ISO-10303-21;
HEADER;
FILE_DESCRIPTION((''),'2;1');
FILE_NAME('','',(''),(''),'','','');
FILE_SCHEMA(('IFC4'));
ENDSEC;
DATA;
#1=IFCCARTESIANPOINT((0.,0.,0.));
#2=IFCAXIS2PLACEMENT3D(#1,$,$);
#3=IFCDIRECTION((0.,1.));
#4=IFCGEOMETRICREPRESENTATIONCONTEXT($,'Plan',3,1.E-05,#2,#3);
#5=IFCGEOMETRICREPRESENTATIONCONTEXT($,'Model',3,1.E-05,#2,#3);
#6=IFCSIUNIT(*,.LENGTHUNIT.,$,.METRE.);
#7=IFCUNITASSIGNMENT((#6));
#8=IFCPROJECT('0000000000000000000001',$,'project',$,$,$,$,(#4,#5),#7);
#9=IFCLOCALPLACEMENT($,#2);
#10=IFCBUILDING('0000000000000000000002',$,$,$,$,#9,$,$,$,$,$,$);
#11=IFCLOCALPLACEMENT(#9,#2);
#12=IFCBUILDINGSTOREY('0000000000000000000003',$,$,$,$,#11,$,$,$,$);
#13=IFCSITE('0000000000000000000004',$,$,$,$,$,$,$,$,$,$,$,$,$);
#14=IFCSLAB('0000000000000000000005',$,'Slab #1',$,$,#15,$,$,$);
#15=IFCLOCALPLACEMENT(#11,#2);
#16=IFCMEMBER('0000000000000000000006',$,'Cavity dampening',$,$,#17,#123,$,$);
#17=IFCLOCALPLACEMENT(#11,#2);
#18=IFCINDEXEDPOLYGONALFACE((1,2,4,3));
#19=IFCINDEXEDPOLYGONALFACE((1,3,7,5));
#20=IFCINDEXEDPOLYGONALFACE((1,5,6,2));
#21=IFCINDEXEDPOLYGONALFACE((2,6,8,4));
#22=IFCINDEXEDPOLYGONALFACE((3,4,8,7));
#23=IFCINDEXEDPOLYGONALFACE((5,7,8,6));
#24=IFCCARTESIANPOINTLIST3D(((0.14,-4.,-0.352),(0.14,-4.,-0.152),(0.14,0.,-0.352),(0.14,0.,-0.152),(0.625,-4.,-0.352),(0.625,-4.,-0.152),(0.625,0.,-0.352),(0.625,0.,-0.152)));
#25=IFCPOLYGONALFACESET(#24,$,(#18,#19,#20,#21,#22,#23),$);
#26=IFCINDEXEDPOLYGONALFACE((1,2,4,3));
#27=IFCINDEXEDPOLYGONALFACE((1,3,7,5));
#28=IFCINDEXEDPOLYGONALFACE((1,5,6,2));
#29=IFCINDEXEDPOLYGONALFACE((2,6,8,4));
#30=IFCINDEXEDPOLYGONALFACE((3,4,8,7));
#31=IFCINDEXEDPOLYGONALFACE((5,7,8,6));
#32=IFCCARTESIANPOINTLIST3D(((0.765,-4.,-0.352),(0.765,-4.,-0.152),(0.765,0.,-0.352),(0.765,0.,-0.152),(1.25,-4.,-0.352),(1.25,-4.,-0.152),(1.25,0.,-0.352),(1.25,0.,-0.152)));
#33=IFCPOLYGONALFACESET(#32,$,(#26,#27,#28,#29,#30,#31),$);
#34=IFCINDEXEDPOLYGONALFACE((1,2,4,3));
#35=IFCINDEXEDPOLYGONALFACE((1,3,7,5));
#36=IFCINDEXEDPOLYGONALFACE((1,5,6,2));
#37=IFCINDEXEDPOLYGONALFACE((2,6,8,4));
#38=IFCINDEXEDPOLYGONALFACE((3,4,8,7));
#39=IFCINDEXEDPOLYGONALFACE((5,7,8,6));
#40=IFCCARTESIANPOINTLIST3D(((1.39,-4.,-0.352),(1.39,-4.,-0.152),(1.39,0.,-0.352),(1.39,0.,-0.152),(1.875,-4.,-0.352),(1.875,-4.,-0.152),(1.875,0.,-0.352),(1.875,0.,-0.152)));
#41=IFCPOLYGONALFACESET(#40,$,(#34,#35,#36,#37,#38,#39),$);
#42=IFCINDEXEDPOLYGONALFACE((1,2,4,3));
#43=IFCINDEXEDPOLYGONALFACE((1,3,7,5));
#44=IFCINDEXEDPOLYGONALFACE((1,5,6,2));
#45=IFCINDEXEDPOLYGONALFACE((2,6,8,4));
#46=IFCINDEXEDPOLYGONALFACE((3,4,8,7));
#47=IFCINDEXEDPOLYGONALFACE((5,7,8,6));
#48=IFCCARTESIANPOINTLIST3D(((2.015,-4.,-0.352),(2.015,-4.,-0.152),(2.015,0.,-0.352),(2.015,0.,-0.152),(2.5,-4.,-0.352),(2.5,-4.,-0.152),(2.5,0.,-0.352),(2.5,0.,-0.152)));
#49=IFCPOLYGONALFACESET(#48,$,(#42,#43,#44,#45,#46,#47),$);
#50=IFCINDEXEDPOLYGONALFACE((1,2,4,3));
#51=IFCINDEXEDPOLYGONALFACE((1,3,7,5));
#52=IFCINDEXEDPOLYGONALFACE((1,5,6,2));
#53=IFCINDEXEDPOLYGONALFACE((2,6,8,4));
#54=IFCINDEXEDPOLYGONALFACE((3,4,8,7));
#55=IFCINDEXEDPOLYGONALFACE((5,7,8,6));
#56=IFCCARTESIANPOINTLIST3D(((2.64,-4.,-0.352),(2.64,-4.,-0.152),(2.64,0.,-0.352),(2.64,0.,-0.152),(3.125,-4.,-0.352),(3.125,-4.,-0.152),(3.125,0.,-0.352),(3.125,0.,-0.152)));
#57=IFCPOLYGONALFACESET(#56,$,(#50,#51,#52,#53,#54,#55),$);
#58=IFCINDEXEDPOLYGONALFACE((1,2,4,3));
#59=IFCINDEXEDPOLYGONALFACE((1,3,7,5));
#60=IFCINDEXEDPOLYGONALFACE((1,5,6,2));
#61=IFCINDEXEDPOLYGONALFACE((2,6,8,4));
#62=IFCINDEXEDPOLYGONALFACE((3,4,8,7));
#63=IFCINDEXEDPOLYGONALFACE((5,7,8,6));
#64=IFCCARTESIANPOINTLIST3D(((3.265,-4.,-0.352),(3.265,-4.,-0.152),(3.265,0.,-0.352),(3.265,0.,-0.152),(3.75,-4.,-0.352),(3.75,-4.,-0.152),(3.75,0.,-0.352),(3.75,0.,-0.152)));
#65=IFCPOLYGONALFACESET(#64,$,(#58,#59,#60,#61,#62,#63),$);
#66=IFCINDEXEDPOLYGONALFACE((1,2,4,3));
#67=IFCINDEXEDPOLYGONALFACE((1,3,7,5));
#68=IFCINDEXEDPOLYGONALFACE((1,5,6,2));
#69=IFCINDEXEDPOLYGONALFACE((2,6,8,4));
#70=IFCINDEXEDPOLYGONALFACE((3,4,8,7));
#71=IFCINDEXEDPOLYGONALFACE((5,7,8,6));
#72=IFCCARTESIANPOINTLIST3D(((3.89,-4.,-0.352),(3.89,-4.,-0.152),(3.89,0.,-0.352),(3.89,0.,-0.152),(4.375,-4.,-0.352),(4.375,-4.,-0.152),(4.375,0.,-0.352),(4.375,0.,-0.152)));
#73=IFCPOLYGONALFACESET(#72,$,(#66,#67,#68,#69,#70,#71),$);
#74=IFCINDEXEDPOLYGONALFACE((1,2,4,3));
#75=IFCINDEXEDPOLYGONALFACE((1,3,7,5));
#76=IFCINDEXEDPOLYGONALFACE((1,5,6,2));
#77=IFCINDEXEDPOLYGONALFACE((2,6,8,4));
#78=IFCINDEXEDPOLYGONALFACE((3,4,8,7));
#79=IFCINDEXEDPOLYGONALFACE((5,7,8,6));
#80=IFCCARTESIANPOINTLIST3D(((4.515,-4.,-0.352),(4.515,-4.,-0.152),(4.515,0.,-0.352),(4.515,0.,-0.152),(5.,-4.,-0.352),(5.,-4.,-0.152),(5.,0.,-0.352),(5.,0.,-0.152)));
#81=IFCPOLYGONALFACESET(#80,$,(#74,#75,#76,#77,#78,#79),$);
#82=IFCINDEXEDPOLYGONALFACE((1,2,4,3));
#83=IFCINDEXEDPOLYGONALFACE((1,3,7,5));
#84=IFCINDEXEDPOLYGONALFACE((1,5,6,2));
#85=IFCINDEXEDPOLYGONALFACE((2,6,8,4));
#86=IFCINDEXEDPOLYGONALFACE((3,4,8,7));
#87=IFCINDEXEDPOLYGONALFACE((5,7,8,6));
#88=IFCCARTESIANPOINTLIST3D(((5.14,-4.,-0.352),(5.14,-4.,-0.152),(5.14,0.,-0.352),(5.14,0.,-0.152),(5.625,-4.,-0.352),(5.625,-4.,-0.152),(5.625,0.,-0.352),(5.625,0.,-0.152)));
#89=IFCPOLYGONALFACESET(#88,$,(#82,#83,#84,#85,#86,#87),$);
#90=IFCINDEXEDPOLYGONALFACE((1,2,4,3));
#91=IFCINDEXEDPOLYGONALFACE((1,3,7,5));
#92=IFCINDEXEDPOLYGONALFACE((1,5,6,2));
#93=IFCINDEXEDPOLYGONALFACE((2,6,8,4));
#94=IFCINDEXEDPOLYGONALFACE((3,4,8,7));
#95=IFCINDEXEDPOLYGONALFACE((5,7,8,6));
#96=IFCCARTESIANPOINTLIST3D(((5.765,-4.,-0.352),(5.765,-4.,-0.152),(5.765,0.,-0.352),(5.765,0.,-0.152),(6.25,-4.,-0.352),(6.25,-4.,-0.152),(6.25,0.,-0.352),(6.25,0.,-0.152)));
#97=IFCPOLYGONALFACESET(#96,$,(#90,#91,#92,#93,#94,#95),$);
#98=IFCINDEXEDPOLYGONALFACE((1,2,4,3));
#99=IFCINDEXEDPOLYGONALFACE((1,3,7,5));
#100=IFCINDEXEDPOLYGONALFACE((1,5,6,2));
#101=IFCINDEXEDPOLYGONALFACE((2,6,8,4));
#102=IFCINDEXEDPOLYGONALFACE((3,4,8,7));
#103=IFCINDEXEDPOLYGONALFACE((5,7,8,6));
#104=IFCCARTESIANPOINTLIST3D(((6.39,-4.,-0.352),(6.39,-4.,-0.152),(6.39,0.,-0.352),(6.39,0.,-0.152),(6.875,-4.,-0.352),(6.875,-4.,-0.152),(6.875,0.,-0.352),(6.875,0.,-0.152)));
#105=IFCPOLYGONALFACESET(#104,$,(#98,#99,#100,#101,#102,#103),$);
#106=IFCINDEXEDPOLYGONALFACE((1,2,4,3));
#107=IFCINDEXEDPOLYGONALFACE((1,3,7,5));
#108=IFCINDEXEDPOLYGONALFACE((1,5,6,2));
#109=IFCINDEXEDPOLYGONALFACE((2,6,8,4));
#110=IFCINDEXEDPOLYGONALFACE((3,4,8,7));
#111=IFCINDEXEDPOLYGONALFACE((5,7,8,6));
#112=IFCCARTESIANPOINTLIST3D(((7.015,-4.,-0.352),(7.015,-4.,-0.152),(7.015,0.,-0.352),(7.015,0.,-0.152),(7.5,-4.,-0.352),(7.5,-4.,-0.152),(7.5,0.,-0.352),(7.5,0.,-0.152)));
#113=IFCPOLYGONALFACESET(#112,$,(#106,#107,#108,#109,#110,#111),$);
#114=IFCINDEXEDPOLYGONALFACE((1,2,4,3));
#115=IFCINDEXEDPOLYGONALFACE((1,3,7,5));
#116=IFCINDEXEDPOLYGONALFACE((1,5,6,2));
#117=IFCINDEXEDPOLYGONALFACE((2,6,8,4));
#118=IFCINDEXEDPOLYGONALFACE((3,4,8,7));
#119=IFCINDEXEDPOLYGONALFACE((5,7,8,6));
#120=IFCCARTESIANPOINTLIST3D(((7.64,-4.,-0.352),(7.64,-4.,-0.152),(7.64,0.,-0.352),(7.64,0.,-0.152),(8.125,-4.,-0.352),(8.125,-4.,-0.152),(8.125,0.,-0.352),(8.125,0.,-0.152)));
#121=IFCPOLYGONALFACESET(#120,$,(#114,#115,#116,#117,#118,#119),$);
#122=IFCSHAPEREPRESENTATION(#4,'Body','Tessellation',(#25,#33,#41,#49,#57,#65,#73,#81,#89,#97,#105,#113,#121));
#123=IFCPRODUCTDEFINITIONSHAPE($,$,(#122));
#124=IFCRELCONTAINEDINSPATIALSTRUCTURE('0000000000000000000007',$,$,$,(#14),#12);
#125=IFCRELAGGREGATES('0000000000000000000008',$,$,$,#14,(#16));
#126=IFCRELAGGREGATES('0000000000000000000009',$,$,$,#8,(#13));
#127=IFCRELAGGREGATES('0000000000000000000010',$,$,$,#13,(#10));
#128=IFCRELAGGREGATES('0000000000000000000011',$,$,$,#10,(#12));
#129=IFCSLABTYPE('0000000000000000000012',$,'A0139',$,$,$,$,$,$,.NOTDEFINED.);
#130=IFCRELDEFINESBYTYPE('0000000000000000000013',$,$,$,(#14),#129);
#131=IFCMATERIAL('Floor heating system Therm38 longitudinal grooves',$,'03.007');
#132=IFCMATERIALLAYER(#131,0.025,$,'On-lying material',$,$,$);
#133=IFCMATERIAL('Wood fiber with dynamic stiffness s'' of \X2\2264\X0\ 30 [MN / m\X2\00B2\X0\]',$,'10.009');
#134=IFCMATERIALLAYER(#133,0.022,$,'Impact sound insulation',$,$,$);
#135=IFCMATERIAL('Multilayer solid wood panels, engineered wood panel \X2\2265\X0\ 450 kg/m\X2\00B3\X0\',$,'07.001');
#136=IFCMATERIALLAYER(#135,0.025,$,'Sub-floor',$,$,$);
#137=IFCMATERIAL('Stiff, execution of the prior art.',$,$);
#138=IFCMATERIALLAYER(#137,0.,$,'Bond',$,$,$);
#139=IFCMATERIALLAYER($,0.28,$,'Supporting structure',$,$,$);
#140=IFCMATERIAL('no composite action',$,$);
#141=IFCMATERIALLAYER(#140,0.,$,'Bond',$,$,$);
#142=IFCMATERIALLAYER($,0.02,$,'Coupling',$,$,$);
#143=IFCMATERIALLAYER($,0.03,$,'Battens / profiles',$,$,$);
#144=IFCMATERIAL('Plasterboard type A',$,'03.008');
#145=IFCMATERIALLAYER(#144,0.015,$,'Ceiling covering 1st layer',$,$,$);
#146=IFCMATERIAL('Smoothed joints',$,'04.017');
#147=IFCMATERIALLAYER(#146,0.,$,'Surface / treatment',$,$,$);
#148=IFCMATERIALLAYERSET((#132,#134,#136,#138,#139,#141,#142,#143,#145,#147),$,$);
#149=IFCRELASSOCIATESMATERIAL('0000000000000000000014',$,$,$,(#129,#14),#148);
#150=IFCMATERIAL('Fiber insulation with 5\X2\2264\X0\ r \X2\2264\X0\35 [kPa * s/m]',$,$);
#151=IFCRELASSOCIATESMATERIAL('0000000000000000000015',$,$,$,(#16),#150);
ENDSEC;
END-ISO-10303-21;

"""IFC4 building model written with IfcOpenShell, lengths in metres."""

from ifc_helpers import new_model, si_unit, direction, frame, frame_2d, origin, place, context, project, spatial, rectangle, extrude, material, layer, layer_set, type_object, element, aggregate, save


model = new_model("IFC4")

# Units and contexts
plan_context = context("Plan", 3, precision=1e-05, world=origin(), true_north=direction((0.0, 1.0)))
model_context = context("Model", 3, precision=1e-05, world=origin(), true_north=direction((0.0, 1.0)))
ifc_project = project(units=[si_unit("LENGTHUNIT", "METRE")], contexts=[plan_context, model_context])

# Site, building, storey
site = spatial("IfcSite", under=ifc_project)
building_placement = place(None, origin())
building = spatial("IfcBuilding", under=site, at=building_placement)
storey_placement = place(building_placement, origin())
storey = spatial("IfcBuildingStorey", under=building, at=storey_placement)

# Slab, member
ifc_material_1 = material(Name="Floor heating system Therm38 longitudinal grooves", Category="03.007")
ifc_layer_1 = layer(ifc_material_1, 0.025, Name="On-lying material")
ifc_material_2 = material(Name="Wood fiber with dynamic stiffness s' of ≤ 30 [MN / m²]", Category="10.009")
ifc_layer_2 = layer(ifc_material_2, 0.022, Name="Impact sound insulation")
ifc_material_3 = material(Name="Multilayer solid wood panels, engineered wood panel ≥ 450 kg/m³", Category="07.001")
ifc_layer_3 = layer(ifc_material_3, 0.025, Name="Sub-floor")
ifc_material_4 = material(Name="Stiff, execution of the prior art.")
ifc_layer_4 = layer(ifc_material_4, 0.0, Name="Bond")
ifc_layer_5 = layer(None, 0.28, Name="Supporting structure")
ifc_material_5 = material(Name="no composite action")
ifc_layer_6 = layer(ifc_material_5, 0.0, Name="Bond")
ifc_layer_7 = layer(None, 0.02, Name="Coupling")
ifc_layer_8 = layer(None, 0.03, Name="Battens / profiles")
ifc_material_6 = material(Name="Plasterboard type A", Category="03.008")
ifc_layer_9 = layer(ifc_material_6, 0.015, Name="Ceiling covering 1st layer")
ifc_material_7 = material(Name="Smoothed joints", Category="04.017")
ifc_layer_10 = layer(ifc_material_7, 0.0, Name="Surface / treatment")
ifc_layer_set = layer_set([ifc_layer_1, ifc_layer_2, ifc_layer_3, ifc_layer_4, ifc_layer_5, ifc_layer_6, ifc_layer_7, ifc_layer_8, ifc_layer_9, ifc_layer_10])
slab_type = type_object("IfcSlabType", Name="A0139", PredefinedType="NOTDEFINED", material=ifc_layer_set)
slab_placement = place(None, frame((0.0, 0.0, 0.0), z_axis=(0.0, 0.0, -1.0), x_axis=(1.0, 0.0, 0.0)))
slab = element("IfcSlab", 1, at=slab_placement, inside=storey, type_object=slab_type, material=ifc_layer_set, Name="Slab #1")
ifc_material_8 = material(Name="Fiber insulation with 5≤ r ≤35 [kPa * s/m]")
member_1_placement = place(slab_placement, origin())
member_1 = element("IfcMember", 2, at=member_1_placement, material=ifc_material_8, Name="Cavity dampening", context=plan_context, shape_type="SweptSolid", body=[
    extrude(rectangle(XDim=0.485, YDim=0.2, at=frame_2d((0.2425, 0.1), x_axis=(1.0, 0.0))), frame((0.14, 4.0, 0.152), z_axis=(0.0, -1.0, 0.0), x_axis=(1.0, 0.0, 0.0)), (0.0, 0.0, 1.0), 4.0),
    extrude(rectangle(XDim=0.485, YDim=0.2, at=frame_2d((0.2425, 0.1), x_axis=(1.0, 0.0))), frame((0.765, 4.0, 0.152), z_axis=(0.0, -1.0, 0.0), x_axis=(1.0, 0.0, 0.0)), (0.0, 0.0, 1.0), 4.0),
    extrude(rectangle(XDim=0.485, YDim=0.2, at=frame_2d((0.2425, 0.1), x_axis=(1.0, 0.0))), frame((1.39, 4.0, 0.152), z_axis=(0.0, -1.0, 0.0), x_axis=(1.0, 0.0, 0.0)), (0.0, 0.0, 1.0), 4.0),
    extrude(rectangle(XDim=0.485, YDim=0.2, at=frame_2d((0.2425, 0.1), x_axis=(1.0, 0.0))), frame((2.015, 4.0, 0.152), z_axis=(0.0, -1.0, 0.0), x_axis=(1.0, 0.0, 0.0)), (0.0, 0.0, 1.0), 4.0),
    extrude(rectangle(XDim=0.485, YDim=0.2, at=frame_2d((0.2425, 0.1), x_axis=(1.0, 0.0))), frame((2.64, 4.0, 0.152), z_axis=(0.0, -1.0, 0.0), x_axis=(1.0, 0.0, 0.0)), (0.0, 0.0, 1.0), 4.0),
    extrude(rectangle(XDim=0.485, YDim=0.2, at=frame_2d((0.2425, 0.1), x_axis=(1.0, 0.0))), frame((3.265, 4.0, 0.152), z_axis=(0.0, -1.0, 0.0), x_axis=(1.0, 0.0, 0.0)), (0.0, 0.0, 1.0), 4.0),
    extrude(rectangle(XDim=0.485, YDim=0.2, at=frame_2d((0.2425, 0.1), x_axis=(1.0, 0.0))), frame((3.89, 4.0, 0.152), z_axis=(0.0, -1.0, 0.0), x_axis=(1.0, 0.0, 0.0)), (0.0, 0.0, 1.0), 4.0),
    extrude(rectangle(XDim=0.485, YDim=0.2, at=frame_2d((0.2425, 0.1), x_axis=(1.0, 0.0))), frame((4.515, 4.0, 0.152), z_axis=(0.0, -1.0, 0.0), x_axis=(1.0, 0.0, 0.0)), (0.0, 0.0, 1.0), 4.0),
    extrude(rectangle(XDim=0.485, YDim=0.2, at=frame_2d((0.2425, 0.1), x_axis=(1.0, 0.0))), frame((5.14, 4.0, 0.152), z_axis=(0.0, -1.0, 0.0), x_axis=(1.0, 0.0, 0.0)), (0.0, 0.0, 1.0), 4.0),
    extrude(rectangle(XDim=0.485, YDim=0.2, at=frame_2d((0.2425, 0.1), x_axis=(1.0, 0.0))), frame((5.765, 4.0, 0.152), z_axis=(0.0, -1.0, 0.0), x_axis=(1.0, 0.0, 0.0)), (0.0, 0.0, 1.0), 4.0),
    extrude(rectangle(XDim=0.485, YDim=0.2, at=frame_2d((0.2425, 0.1), x_axis=(1.0, 0.0))), frame((6.39, 4.0, 0.152), z_axis=(0.0, -1.0, 0.0), x_axis=(1.0, 0.0, 0.0)), (0.0, 0.0, 1.0), 4.0),
    extrude(rectangle(XDim=0.485, YDim=0.2, at=frame_2d((0.2425, 0.1), x_axis=(1.0, 0.0))), frame((7.015, 4.0, 0.152), z_axis=(0.0, -1.0, 0.0), x_axis=(1.0, 0.0, 0.0)), (0.0, 0.0, 1.0), 4.0),
    extrude(rectangle(XDim=0.485, YDim=0.2, at=frame_2d((0.2425, 0.1), x_axis=(1.0, 0.0))), frame((7.64, 4.0, 0.152), z_axis=(0.0, -1.0, 0.0), x_axis=(1.0, 0.0, 0.0)), (0.0, 0.0, 1.0), 4.0),
])
aggregate(slab, [member_1])

save(model, "model.ifc")
